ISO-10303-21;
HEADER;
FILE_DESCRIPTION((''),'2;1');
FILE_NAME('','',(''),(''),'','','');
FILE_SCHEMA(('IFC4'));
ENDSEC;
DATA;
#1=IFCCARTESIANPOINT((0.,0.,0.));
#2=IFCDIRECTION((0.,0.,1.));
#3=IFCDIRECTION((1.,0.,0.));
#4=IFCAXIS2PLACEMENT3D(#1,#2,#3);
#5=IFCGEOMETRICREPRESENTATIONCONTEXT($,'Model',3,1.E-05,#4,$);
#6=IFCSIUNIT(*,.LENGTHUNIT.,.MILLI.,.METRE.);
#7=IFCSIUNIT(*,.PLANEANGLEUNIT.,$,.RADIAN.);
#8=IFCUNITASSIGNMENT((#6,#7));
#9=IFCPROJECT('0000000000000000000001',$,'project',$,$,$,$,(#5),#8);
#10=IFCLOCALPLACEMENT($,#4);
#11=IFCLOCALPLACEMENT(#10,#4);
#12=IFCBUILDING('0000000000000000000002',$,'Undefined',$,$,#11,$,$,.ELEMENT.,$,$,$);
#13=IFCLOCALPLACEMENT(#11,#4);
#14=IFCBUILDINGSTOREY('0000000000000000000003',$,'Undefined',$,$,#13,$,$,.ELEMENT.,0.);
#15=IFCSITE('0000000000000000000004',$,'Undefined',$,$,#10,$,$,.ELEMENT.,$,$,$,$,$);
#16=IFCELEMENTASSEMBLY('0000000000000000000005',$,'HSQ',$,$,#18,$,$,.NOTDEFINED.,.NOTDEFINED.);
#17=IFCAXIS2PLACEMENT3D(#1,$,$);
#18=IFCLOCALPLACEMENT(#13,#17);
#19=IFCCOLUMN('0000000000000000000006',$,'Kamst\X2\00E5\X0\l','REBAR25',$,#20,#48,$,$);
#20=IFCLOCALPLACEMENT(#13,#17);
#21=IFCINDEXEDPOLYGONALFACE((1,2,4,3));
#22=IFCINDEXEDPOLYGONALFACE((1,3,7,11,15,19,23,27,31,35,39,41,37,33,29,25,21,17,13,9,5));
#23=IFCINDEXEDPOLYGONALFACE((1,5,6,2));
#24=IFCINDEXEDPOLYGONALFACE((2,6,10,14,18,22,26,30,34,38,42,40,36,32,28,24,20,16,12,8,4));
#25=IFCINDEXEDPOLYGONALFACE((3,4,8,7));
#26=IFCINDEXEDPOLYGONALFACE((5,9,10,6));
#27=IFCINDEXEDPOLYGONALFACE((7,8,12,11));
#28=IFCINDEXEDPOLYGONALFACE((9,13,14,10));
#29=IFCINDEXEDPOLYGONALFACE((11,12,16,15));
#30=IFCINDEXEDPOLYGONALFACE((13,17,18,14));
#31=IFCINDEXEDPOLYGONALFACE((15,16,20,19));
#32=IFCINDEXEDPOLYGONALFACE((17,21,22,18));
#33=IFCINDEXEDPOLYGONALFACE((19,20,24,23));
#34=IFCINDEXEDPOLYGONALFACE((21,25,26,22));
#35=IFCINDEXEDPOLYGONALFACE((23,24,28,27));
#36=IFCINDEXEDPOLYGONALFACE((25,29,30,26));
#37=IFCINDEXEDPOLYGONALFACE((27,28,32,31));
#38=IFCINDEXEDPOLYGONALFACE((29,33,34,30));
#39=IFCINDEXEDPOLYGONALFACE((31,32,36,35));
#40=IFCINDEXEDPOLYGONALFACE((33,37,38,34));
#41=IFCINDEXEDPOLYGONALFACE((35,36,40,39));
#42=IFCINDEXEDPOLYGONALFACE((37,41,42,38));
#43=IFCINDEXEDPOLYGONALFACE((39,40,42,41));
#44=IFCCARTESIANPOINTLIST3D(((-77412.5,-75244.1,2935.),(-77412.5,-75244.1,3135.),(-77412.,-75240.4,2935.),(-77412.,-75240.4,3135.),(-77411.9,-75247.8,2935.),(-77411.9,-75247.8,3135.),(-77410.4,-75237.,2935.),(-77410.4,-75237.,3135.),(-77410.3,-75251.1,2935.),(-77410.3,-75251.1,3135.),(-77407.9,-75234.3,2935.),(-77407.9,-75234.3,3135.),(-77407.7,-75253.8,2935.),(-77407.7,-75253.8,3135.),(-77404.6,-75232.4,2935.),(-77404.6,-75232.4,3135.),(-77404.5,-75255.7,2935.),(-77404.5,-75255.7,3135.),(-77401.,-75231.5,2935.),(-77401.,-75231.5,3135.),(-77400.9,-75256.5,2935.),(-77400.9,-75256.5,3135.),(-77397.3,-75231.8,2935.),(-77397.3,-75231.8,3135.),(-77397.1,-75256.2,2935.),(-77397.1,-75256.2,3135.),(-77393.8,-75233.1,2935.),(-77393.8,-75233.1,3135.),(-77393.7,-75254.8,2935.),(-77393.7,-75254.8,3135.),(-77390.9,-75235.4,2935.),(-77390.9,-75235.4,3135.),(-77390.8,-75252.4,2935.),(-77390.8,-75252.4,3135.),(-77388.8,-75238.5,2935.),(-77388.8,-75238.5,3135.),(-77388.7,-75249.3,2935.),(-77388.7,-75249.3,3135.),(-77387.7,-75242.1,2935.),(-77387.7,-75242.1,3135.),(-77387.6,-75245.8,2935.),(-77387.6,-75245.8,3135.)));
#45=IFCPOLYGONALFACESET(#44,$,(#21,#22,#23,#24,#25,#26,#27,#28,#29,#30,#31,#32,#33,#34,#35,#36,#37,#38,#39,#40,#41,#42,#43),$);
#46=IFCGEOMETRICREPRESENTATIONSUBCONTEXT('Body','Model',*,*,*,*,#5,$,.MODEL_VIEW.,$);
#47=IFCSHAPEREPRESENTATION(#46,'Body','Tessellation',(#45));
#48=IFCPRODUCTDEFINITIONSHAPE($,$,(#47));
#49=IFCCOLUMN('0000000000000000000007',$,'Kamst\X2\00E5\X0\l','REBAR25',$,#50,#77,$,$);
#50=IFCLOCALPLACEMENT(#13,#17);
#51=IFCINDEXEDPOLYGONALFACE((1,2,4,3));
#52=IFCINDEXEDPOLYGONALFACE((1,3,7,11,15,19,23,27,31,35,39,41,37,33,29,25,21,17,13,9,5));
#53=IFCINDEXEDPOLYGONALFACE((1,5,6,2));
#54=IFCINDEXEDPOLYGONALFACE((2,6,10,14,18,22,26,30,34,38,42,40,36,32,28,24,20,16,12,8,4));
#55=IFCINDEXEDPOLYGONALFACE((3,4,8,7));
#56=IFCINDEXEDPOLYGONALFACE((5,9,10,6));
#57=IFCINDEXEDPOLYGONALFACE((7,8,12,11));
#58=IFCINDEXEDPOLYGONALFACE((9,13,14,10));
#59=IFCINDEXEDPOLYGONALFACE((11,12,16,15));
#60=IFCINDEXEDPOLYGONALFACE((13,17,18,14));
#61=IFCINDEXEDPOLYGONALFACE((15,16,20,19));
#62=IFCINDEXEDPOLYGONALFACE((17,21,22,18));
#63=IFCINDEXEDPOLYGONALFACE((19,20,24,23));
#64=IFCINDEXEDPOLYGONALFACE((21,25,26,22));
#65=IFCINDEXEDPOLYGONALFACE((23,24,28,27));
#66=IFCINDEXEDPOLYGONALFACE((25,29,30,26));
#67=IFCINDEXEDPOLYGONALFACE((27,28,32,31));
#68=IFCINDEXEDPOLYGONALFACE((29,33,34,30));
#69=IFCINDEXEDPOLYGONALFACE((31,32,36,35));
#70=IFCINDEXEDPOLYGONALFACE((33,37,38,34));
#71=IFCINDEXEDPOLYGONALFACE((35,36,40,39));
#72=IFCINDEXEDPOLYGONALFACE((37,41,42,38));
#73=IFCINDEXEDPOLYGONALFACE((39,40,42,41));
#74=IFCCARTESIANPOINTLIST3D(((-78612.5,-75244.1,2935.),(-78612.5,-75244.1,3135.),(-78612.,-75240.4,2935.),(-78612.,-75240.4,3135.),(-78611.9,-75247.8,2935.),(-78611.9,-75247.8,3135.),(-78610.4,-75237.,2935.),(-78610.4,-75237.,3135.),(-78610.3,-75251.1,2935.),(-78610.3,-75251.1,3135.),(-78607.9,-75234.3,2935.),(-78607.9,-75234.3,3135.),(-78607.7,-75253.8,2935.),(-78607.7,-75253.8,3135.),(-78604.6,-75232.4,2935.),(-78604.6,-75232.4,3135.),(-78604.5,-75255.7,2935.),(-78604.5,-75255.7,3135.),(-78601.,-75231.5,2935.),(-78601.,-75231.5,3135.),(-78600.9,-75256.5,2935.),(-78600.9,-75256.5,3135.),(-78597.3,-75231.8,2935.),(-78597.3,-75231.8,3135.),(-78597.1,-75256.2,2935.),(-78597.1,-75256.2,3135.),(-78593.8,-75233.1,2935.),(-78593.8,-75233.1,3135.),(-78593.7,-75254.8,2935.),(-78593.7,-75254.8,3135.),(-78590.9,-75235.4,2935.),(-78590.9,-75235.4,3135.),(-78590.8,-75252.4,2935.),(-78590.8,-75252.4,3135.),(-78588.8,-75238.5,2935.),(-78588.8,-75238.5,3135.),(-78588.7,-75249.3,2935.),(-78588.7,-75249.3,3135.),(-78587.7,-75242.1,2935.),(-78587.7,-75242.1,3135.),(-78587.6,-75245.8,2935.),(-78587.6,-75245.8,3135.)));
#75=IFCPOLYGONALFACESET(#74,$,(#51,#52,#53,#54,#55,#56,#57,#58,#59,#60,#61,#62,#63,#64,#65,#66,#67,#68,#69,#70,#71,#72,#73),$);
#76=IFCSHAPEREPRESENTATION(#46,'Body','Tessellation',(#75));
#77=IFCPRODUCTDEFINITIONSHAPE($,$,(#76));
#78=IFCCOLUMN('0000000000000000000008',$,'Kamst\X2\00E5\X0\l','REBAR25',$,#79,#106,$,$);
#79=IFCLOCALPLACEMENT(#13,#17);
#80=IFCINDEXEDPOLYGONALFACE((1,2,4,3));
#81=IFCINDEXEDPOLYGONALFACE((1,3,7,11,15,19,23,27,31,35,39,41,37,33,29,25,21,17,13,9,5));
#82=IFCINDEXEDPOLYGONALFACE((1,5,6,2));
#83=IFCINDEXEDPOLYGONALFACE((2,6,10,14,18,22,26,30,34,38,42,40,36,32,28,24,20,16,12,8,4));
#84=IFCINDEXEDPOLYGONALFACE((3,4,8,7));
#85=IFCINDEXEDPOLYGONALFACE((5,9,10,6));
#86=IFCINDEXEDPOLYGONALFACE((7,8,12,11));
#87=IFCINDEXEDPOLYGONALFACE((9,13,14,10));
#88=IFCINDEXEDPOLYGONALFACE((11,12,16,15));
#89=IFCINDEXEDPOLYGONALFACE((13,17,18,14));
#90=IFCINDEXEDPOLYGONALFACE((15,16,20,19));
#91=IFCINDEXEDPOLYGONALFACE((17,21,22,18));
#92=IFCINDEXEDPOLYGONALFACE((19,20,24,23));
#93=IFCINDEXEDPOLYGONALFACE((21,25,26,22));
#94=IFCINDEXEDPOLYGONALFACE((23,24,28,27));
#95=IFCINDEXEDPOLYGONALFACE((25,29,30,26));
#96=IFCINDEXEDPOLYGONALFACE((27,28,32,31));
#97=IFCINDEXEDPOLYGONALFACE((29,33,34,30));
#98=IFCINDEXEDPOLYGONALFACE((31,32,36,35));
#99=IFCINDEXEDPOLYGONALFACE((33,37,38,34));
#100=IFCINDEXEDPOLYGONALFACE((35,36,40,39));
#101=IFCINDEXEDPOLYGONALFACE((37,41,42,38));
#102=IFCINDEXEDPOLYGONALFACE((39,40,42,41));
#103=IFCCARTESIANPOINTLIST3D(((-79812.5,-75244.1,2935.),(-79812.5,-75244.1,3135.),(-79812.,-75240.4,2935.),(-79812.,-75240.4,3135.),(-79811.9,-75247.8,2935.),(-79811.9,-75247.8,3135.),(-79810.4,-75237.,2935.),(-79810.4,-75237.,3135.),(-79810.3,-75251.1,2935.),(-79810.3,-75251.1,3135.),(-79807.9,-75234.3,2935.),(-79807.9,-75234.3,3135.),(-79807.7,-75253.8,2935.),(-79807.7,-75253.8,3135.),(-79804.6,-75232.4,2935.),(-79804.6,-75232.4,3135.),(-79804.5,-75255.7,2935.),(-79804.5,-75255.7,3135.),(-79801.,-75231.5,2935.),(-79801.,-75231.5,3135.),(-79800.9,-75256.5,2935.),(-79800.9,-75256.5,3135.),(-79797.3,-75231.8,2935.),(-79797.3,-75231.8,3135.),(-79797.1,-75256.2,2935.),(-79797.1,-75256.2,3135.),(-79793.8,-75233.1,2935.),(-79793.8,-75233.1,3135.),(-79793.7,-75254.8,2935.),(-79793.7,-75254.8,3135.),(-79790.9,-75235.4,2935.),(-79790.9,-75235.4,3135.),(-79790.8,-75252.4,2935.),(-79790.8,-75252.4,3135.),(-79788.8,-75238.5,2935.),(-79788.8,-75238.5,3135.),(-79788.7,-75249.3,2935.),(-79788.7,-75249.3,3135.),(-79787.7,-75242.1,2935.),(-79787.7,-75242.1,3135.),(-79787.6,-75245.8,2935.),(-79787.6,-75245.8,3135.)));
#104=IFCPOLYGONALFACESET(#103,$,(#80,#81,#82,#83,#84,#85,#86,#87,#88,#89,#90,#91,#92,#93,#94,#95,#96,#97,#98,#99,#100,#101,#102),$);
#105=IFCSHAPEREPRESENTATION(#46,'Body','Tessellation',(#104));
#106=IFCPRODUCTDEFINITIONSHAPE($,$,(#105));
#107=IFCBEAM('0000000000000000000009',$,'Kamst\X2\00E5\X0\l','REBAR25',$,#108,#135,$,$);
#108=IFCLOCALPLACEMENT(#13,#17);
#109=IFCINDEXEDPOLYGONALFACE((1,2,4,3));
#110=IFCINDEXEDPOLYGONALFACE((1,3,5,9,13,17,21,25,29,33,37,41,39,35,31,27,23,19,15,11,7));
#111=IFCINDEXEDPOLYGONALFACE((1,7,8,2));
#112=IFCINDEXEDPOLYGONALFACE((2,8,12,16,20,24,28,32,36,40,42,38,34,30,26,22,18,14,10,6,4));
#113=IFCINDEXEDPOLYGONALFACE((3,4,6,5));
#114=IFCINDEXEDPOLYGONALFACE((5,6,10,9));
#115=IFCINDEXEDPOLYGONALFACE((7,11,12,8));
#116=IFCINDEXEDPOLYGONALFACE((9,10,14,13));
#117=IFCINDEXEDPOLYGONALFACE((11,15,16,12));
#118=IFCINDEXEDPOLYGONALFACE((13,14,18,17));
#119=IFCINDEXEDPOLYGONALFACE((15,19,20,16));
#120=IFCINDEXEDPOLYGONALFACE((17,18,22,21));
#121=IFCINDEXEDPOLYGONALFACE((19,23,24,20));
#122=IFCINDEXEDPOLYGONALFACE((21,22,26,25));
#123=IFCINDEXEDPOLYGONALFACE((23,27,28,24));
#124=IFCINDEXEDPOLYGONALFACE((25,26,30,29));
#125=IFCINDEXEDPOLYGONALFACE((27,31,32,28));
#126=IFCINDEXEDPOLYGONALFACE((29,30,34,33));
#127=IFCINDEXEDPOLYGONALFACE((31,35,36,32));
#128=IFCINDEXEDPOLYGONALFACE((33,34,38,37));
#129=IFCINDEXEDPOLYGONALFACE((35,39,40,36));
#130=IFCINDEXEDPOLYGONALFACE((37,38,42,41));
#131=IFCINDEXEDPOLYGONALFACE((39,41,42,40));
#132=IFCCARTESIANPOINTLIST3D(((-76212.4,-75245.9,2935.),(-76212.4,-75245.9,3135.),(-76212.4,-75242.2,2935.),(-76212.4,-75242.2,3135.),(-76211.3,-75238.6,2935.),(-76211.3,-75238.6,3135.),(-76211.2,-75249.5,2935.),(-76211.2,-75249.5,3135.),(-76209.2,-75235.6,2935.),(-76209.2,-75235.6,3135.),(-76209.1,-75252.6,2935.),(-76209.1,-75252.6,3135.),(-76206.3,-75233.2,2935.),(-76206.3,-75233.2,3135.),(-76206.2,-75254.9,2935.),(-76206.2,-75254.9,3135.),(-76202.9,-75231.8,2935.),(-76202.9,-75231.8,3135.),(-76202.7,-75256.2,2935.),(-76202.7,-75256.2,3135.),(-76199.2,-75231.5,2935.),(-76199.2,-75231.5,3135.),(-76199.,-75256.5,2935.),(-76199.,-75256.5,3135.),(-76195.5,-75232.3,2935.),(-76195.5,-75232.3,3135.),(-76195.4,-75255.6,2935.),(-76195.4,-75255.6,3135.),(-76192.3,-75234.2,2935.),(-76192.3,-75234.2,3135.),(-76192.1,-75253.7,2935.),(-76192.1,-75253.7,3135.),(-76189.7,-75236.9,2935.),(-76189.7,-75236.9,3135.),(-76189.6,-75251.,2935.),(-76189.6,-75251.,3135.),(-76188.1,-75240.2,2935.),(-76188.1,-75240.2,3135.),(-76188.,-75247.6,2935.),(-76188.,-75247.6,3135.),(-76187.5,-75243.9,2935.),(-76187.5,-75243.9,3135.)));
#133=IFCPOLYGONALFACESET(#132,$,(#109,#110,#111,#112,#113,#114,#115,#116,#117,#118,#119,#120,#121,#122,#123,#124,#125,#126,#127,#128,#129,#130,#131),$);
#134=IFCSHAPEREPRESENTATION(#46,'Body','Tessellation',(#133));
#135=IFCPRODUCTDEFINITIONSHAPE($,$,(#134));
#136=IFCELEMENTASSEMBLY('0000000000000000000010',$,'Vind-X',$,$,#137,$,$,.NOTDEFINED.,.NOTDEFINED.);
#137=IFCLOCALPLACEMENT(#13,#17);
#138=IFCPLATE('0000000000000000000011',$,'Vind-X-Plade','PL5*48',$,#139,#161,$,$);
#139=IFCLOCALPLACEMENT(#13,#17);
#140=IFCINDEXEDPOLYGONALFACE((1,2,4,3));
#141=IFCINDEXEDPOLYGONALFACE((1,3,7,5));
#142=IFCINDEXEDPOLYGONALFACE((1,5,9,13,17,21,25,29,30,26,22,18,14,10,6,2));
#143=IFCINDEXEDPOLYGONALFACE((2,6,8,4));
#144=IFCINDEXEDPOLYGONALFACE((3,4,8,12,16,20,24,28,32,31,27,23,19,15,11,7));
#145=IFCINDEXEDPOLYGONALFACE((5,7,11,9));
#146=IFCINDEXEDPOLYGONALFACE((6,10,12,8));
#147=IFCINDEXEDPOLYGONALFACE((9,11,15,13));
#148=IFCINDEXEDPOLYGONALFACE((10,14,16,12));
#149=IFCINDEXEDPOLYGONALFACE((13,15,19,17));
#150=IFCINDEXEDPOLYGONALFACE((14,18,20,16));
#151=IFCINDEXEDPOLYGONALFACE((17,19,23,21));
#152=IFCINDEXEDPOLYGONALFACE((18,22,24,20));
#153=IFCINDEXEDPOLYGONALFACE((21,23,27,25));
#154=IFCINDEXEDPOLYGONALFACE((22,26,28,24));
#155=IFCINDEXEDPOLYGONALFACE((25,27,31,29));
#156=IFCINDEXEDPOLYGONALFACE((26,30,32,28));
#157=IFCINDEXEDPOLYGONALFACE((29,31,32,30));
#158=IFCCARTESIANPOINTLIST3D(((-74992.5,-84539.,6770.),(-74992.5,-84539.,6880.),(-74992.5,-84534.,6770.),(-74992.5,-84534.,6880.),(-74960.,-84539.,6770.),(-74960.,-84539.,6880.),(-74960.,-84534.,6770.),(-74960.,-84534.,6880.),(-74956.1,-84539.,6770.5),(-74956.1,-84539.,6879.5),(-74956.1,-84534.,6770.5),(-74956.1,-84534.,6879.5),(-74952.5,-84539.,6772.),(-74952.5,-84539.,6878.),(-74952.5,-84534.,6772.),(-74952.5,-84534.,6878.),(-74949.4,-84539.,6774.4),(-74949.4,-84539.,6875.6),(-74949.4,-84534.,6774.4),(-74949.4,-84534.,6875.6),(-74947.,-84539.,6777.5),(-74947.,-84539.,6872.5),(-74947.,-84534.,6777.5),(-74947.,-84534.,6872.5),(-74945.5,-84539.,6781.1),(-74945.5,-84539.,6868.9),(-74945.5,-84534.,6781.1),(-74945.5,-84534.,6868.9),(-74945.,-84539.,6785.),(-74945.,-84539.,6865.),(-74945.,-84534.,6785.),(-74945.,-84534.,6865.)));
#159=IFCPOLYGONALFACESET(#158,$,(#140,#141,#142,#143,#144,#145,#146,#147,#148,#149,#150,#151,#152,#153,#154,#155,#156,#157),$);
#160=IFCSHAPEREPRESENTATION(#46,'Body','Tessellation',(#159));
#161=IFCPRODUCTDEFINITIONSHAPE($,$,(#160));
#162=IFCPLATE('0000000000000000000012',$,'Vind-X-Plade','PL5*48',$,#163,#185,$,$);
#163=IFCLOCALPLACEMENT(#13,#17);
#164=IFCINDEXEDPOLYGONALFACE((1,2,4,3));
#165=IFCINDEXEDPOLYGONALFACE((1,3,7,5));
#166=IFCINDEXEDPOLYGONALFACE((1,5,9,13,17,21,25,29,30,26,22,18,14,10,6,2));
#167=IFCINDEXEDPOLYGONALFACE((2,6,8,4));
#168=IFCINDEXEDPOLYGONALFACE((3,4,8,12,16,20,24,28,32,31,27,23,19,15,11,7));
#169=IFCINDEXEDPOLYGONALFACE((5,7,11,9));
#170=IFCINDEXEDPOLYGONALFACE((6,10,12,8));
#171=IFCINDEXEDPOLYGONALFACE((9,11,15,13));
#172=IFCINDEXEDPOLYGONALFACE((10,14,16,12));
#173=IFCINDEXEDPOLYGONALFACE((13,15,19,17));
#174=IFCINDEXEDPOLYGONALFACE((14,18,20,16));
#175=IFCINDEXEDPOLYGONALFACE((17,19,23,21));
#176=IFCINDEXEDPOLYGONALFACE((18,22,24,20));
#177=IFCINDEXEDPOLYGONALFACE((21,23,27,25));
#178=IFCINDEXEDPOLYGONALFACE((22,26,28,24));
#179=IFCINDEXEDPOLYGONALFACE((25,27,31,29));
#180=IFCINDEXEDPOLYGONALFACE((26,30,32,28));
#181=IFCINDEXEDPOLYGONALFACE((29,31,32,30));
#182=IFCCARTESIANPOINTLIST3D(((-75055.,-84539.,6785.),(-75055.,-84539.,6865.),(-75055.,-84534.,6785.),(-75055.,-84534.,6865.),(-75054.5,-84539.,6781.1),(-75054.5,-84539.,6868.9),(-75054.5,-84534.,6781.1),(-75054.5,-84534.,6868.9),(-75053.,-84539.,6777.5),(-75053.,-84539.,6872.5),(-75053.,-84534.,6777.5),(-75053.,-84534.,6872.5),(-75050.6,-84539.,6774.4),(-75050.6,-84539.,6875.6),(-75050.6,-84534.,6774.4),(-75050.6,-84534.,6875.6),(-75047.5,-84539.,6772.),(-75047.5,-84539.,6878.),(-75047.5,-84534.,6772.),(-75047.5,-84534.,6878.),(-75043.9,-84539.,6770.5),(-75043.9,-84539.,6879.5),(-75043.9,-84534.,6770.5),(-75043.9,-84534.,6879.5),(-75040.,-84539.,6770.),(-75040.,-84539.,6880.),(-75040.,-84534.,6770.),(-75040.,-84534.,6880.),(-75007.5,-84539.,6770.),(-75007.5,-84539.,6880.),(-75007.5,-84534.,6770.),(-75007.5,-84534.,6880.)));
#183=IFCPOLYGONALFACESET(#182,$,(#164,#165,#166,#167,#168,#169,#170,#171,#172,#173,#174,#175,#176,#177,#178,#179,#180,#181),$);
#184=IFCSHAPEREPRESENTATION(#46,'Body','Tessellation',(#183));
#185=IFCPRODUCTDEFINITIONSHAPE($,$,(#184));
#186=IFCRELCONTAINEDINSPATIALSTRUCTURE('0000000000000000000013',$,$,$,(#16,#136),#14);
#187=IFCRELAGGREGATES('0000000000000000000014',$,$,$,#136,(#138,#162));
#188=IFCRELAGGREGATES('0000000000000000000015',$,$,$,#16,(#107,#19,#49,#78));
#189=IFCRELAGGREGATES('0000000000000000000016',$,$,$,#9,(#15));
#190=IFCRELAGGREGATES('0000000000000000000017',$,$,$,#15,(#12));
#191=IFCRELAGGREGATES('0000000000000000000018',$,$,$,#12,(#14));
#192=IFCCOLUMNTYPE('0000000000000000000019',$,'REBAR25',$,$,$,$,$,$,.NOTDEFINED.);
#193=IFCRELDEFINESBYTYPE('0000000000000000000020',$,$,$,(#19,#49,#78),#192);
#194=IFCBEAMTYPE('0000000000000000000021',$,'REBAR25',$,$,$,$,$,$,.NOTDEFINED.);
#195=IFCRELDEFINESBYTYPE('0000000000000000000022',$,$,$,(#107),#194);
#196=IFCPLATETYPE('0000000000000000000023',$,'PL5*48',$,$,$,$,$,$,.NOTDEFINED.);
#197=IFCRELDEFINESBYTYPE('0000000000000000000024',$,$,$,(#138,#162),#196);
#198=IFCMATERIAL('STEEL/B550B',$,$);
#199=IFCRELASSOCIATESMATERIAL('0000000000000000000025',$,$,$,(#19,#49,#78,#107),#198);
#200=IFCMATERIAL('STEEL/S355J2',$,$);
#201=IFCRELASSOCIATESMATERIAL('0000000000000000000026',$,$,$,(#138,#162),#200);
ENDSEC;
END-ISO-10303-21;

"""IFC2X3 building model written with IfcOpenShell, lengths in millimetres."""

from ifc_helpers import new_model, si_unit, frame, frame_2d, origin_with_axes, origin_2d_with_axis, place, context, subcontext, project, spatial, polyline, circle_curve, parameter, trimmed, segment, composite_curve, circle, outline, extrude, material, type_object, element, aggregate, save


model = new_model("IFC2X3")

# Units and contexts
model_context = context("Model", 3, precision=1e-05, world=origin_with_axes())
body_context = subcontext(model_context, "Body", "Model", "MODEL_VIEW")
ifc_project = project(units=[si_unit("LENGTHUNIT", "METRE", prefix="MILLI"), si_unit("PLANEANGLEUNIT", "RADIAN")], contexts=[model_context])

# Site, building, storey
site_placement = place(None, origin_with_axes())
site = spatial("IfcSite", under=ifc_project, at=site_placement, Name="Undefined", CompositionType="ELEMENT")
building_placement = place(site_placement, origin_with_axes())
building = spatial("IfcBuilding", under=site, at=building_placement, Name="Undefined", CompositionType="ELEMENT")
storey_placement = place(building_placement, origin_with_axes())
storey = spatial("IfcBuildingStorey", under=building, at=storey_placement, Name="Undefined", CompositionType="ELEMENT", Elevation=0.0)

# Element assembly, columns, beam
assembly_1_placement = place(storey_placement, origin_with_axes())
assembly_1 = element("IfcElementAssembly", 1, at=assembly_1_placement, inside=storey, Name="HSQ", AssemblyPlace="NOTDEFINED", PredefinedType="NOTDEFINED")
ifc_material_1 = material(Name="STEEL/B550B")
column_type = type_object("IfcColumnType", Name="REBAR25", PredefinedType="NOTDEFINED")
column_1_placement = place(assembly_1_placement, frame((-77400.0, -75244.0, 2935.0), z_axis=(0.0, 0.0, 1.0), x_axis=(-0.862746, -0.505638, 0.0)))
column_1 = element("IfcColumn", 2, at=column_1_placement, type_object=column_type, material=ifc_material_1, Name="Kamstål", Description="REBAR25", context=body_context, shape_type="SweptSolid", body=[
    extrude(circle(Radius=12.5, at=origin_2d_with_axis()), frame((0.0, 0.0, 200.0), z_axis=(0.0, 0.0, -1.0), x_axis=(0.0, 1.0, 0.0)), (0.0, 0.0, 1.0), 200.0),
])
column_2_placement = place(assembly_1_placement, frame((-78600.0, -75244.0, 2935.0), z_axis=(0.0, 0.0, 1.0), x_axis=(-0.862746, -0.505638, 0.0)))
column_2 = element("IfcColumn", 3, at=column_2_placement, type_object=column_type, material=ifc_material_1, Name="Kamstål", Description="REBAR25", context=body_context, shape_type="SweptSolid", body=[
    extrude(circle(Radius=12.5, at=origin_2d_with_axis()), frame((0.0, 0.0, 200.0), z_axis=(0.0, 0.0, -1.0), x_axis=(0.0, 1.0, 0.0)), (0.0, 0.0, 1.0), 200.0),
])
column_3_placement = place(assembly_1_placement, frame((-79800.0, -75244.0, 2935.0), z_axis=(0.0, 0.0, 1.0), x_axis=(-0.862746, -0.505638, 0.0)))
column_3 = element("IfcColumn", 4, at=column_3_placement, type_object=column_type, material=ifc_material_1, Name="Kamstål", Description="REBAR25", context=body_context, shape_type="SweptSolid", body=[
    extrude(circle(Radius=12.5, at=origin_2d_with_axis()), frame((0.0, 0.0, 200.0), z_axis=(0.0, 0.0, -1.0), x_axis=(0.0, 1.0, 0.0)), (0.0, 0.0, 1.0), 200.0),
])
beam_type_1 = type_object("IfcBeamType", Name="REBAR25", PredefinedType="NOTDEFINED")
beam_1_placement = place(assembly_1_placement, frame((-76200.0, -75244.0, 3135.0), z_axis=(-0.862746, -0.505638, 0.0), x_axis=(0.0, 0.0, -1.0)))
beam_1 = element("IfcBeam", 5, at=beam_1_placement, type_object=beam_type_1, material=ifc_material_1, Name="Kamstål", Description="REBAR25", context=body_context, shape_type="SweptSolid", body=[
    extrude(circle(Radius=12.5, at=origin_2d_with_axis()), frame((200.0, 0.0, 0.0), z_axis=(-1.0, 0.0, 0.0), x_axis=(0.0, -1.0, 0.0)), (0.0, 0.0, 1.0), 200.0),
])

# Shared definitions
ifc_material_2 = material(Name="STEEL/S355J2")

# Element assembly, plates
assembly_2_placement = place(storey_placement, origin_with_axes())
assembly_2 = element("IfcElementAssembly", 6, at=assembly_2_placement, inside=storey, Name="Vind-X", AssemblyPlace="NOTDEFINED", PredefinedType="NOTDEFINED")
plate_type_1 = type_object("IfcPlateType", Name="PL5*48", PredefinedType="NOTDEFINED")
plate_1_placement = place(assembly_2_placement, frame((-74945.0, -84536.5, 6770.0), z_axis=(0.0, 1.0, 0.0), x_axis=(-1.0, 0.0, 0.0)))
plate_1 = element("IfcPlate", 7, at=plate_1_placement, type_object=plate_type_1, material=ifc_material_2, Name="Vind-X-Plade", Description="PL5*48", context=body_context, shape_type="SweptSolid", body=[
    extrude(outline(composite_curve([segment(trimmed(circle_curve(frame_2d((15.0, 15.0), x_axis=(-1.0, 0.0)), 15.0), [parameter(0.0)], [parameter(1.570796)], True, "PARAMETER"), True, "CONTINUOUS"), segment(polyline([(15.0, 0.0), (47.5, 0.0), (47.5, 110.0), (15.0, 110.0)]), True, "CONTINUOUS"), segment(trimmed(circle_curve(frame_2d((15.0, 95.0), x_axis=(0.0, 1.0)), 15.0), [parameter(0.0)], [parameter(1.570796)], True, "PARAMETER"), True, "CONTINUOUS"), segment(polyline([(0.0, 95.0), (0.0, 15.0)]), True, "CONTINUOUS")], self_intersect=True)), frame((0.0, 0.0, -2.5), z_axis=(0.0, 0.0, 1.0), x_axis=(1.0, 0.0, 0.0)), (0.0, 0.0, 1.0), 5.0),
])
plate_2_placement = place(assembly_2_placement, frame((-75007.5, -84536.5, 6770.0), z_axis=(0.0, 1.0, 0.0), x_axis=(-1.0, 0.0, 0.0)))
plate_2 = element("IfcPlate", 8, at=plate_2_placement, type_object=plate_type_1, material=ifc_material_2, Name="Vind-X-Plade", Description="PL5*48", context=body_context, shape_type="SweptSolid", body=[
    extrude(outline(composite_curve([segment(polyline([(0.0, 0.0), (32.5, 0.0)]), True, "CONTINUOUS"), segment(trimmed(circle_curve(frame_2d((32.5, 15.0), x_axis=(0.0, -1.0)), 15.0), [parameter(0.0)], [parameter(1.570796)], True, "PARAMETER"), True, "CONTINUOUS"), segment(polyline([(47.5, 15.0), (47.5, 95.0)]), True, "CONTINUOUS"), segment(trimmed(circle_curve(frame_2d((32.5, 95.0), x_axis=(1.0, 0.0)), 15.0), [parameter(0.0)], [parameter(1.570796)], True, "PARAMETER"), True, "CONTINUOUS"), segment(polyline([(32.5, 110.0), (0.0, 110.0), (0.0, 0.0)]), True, "CONTINUOUS")], self_intersect=True)), frame((0.0, 0.0, -2.5), z_axis=(0.0, 0.0, 1.0), x_axis=(1.0, 0.0, 0.0)), (0.0, 0.0, 1.0), 5.0),
])

aggregate(assembly_2, [plate_1, plate_2])

aggregate(assembly_1, [beam_1, column_1, column_2, column_3])

save(model, "model.ifc")
